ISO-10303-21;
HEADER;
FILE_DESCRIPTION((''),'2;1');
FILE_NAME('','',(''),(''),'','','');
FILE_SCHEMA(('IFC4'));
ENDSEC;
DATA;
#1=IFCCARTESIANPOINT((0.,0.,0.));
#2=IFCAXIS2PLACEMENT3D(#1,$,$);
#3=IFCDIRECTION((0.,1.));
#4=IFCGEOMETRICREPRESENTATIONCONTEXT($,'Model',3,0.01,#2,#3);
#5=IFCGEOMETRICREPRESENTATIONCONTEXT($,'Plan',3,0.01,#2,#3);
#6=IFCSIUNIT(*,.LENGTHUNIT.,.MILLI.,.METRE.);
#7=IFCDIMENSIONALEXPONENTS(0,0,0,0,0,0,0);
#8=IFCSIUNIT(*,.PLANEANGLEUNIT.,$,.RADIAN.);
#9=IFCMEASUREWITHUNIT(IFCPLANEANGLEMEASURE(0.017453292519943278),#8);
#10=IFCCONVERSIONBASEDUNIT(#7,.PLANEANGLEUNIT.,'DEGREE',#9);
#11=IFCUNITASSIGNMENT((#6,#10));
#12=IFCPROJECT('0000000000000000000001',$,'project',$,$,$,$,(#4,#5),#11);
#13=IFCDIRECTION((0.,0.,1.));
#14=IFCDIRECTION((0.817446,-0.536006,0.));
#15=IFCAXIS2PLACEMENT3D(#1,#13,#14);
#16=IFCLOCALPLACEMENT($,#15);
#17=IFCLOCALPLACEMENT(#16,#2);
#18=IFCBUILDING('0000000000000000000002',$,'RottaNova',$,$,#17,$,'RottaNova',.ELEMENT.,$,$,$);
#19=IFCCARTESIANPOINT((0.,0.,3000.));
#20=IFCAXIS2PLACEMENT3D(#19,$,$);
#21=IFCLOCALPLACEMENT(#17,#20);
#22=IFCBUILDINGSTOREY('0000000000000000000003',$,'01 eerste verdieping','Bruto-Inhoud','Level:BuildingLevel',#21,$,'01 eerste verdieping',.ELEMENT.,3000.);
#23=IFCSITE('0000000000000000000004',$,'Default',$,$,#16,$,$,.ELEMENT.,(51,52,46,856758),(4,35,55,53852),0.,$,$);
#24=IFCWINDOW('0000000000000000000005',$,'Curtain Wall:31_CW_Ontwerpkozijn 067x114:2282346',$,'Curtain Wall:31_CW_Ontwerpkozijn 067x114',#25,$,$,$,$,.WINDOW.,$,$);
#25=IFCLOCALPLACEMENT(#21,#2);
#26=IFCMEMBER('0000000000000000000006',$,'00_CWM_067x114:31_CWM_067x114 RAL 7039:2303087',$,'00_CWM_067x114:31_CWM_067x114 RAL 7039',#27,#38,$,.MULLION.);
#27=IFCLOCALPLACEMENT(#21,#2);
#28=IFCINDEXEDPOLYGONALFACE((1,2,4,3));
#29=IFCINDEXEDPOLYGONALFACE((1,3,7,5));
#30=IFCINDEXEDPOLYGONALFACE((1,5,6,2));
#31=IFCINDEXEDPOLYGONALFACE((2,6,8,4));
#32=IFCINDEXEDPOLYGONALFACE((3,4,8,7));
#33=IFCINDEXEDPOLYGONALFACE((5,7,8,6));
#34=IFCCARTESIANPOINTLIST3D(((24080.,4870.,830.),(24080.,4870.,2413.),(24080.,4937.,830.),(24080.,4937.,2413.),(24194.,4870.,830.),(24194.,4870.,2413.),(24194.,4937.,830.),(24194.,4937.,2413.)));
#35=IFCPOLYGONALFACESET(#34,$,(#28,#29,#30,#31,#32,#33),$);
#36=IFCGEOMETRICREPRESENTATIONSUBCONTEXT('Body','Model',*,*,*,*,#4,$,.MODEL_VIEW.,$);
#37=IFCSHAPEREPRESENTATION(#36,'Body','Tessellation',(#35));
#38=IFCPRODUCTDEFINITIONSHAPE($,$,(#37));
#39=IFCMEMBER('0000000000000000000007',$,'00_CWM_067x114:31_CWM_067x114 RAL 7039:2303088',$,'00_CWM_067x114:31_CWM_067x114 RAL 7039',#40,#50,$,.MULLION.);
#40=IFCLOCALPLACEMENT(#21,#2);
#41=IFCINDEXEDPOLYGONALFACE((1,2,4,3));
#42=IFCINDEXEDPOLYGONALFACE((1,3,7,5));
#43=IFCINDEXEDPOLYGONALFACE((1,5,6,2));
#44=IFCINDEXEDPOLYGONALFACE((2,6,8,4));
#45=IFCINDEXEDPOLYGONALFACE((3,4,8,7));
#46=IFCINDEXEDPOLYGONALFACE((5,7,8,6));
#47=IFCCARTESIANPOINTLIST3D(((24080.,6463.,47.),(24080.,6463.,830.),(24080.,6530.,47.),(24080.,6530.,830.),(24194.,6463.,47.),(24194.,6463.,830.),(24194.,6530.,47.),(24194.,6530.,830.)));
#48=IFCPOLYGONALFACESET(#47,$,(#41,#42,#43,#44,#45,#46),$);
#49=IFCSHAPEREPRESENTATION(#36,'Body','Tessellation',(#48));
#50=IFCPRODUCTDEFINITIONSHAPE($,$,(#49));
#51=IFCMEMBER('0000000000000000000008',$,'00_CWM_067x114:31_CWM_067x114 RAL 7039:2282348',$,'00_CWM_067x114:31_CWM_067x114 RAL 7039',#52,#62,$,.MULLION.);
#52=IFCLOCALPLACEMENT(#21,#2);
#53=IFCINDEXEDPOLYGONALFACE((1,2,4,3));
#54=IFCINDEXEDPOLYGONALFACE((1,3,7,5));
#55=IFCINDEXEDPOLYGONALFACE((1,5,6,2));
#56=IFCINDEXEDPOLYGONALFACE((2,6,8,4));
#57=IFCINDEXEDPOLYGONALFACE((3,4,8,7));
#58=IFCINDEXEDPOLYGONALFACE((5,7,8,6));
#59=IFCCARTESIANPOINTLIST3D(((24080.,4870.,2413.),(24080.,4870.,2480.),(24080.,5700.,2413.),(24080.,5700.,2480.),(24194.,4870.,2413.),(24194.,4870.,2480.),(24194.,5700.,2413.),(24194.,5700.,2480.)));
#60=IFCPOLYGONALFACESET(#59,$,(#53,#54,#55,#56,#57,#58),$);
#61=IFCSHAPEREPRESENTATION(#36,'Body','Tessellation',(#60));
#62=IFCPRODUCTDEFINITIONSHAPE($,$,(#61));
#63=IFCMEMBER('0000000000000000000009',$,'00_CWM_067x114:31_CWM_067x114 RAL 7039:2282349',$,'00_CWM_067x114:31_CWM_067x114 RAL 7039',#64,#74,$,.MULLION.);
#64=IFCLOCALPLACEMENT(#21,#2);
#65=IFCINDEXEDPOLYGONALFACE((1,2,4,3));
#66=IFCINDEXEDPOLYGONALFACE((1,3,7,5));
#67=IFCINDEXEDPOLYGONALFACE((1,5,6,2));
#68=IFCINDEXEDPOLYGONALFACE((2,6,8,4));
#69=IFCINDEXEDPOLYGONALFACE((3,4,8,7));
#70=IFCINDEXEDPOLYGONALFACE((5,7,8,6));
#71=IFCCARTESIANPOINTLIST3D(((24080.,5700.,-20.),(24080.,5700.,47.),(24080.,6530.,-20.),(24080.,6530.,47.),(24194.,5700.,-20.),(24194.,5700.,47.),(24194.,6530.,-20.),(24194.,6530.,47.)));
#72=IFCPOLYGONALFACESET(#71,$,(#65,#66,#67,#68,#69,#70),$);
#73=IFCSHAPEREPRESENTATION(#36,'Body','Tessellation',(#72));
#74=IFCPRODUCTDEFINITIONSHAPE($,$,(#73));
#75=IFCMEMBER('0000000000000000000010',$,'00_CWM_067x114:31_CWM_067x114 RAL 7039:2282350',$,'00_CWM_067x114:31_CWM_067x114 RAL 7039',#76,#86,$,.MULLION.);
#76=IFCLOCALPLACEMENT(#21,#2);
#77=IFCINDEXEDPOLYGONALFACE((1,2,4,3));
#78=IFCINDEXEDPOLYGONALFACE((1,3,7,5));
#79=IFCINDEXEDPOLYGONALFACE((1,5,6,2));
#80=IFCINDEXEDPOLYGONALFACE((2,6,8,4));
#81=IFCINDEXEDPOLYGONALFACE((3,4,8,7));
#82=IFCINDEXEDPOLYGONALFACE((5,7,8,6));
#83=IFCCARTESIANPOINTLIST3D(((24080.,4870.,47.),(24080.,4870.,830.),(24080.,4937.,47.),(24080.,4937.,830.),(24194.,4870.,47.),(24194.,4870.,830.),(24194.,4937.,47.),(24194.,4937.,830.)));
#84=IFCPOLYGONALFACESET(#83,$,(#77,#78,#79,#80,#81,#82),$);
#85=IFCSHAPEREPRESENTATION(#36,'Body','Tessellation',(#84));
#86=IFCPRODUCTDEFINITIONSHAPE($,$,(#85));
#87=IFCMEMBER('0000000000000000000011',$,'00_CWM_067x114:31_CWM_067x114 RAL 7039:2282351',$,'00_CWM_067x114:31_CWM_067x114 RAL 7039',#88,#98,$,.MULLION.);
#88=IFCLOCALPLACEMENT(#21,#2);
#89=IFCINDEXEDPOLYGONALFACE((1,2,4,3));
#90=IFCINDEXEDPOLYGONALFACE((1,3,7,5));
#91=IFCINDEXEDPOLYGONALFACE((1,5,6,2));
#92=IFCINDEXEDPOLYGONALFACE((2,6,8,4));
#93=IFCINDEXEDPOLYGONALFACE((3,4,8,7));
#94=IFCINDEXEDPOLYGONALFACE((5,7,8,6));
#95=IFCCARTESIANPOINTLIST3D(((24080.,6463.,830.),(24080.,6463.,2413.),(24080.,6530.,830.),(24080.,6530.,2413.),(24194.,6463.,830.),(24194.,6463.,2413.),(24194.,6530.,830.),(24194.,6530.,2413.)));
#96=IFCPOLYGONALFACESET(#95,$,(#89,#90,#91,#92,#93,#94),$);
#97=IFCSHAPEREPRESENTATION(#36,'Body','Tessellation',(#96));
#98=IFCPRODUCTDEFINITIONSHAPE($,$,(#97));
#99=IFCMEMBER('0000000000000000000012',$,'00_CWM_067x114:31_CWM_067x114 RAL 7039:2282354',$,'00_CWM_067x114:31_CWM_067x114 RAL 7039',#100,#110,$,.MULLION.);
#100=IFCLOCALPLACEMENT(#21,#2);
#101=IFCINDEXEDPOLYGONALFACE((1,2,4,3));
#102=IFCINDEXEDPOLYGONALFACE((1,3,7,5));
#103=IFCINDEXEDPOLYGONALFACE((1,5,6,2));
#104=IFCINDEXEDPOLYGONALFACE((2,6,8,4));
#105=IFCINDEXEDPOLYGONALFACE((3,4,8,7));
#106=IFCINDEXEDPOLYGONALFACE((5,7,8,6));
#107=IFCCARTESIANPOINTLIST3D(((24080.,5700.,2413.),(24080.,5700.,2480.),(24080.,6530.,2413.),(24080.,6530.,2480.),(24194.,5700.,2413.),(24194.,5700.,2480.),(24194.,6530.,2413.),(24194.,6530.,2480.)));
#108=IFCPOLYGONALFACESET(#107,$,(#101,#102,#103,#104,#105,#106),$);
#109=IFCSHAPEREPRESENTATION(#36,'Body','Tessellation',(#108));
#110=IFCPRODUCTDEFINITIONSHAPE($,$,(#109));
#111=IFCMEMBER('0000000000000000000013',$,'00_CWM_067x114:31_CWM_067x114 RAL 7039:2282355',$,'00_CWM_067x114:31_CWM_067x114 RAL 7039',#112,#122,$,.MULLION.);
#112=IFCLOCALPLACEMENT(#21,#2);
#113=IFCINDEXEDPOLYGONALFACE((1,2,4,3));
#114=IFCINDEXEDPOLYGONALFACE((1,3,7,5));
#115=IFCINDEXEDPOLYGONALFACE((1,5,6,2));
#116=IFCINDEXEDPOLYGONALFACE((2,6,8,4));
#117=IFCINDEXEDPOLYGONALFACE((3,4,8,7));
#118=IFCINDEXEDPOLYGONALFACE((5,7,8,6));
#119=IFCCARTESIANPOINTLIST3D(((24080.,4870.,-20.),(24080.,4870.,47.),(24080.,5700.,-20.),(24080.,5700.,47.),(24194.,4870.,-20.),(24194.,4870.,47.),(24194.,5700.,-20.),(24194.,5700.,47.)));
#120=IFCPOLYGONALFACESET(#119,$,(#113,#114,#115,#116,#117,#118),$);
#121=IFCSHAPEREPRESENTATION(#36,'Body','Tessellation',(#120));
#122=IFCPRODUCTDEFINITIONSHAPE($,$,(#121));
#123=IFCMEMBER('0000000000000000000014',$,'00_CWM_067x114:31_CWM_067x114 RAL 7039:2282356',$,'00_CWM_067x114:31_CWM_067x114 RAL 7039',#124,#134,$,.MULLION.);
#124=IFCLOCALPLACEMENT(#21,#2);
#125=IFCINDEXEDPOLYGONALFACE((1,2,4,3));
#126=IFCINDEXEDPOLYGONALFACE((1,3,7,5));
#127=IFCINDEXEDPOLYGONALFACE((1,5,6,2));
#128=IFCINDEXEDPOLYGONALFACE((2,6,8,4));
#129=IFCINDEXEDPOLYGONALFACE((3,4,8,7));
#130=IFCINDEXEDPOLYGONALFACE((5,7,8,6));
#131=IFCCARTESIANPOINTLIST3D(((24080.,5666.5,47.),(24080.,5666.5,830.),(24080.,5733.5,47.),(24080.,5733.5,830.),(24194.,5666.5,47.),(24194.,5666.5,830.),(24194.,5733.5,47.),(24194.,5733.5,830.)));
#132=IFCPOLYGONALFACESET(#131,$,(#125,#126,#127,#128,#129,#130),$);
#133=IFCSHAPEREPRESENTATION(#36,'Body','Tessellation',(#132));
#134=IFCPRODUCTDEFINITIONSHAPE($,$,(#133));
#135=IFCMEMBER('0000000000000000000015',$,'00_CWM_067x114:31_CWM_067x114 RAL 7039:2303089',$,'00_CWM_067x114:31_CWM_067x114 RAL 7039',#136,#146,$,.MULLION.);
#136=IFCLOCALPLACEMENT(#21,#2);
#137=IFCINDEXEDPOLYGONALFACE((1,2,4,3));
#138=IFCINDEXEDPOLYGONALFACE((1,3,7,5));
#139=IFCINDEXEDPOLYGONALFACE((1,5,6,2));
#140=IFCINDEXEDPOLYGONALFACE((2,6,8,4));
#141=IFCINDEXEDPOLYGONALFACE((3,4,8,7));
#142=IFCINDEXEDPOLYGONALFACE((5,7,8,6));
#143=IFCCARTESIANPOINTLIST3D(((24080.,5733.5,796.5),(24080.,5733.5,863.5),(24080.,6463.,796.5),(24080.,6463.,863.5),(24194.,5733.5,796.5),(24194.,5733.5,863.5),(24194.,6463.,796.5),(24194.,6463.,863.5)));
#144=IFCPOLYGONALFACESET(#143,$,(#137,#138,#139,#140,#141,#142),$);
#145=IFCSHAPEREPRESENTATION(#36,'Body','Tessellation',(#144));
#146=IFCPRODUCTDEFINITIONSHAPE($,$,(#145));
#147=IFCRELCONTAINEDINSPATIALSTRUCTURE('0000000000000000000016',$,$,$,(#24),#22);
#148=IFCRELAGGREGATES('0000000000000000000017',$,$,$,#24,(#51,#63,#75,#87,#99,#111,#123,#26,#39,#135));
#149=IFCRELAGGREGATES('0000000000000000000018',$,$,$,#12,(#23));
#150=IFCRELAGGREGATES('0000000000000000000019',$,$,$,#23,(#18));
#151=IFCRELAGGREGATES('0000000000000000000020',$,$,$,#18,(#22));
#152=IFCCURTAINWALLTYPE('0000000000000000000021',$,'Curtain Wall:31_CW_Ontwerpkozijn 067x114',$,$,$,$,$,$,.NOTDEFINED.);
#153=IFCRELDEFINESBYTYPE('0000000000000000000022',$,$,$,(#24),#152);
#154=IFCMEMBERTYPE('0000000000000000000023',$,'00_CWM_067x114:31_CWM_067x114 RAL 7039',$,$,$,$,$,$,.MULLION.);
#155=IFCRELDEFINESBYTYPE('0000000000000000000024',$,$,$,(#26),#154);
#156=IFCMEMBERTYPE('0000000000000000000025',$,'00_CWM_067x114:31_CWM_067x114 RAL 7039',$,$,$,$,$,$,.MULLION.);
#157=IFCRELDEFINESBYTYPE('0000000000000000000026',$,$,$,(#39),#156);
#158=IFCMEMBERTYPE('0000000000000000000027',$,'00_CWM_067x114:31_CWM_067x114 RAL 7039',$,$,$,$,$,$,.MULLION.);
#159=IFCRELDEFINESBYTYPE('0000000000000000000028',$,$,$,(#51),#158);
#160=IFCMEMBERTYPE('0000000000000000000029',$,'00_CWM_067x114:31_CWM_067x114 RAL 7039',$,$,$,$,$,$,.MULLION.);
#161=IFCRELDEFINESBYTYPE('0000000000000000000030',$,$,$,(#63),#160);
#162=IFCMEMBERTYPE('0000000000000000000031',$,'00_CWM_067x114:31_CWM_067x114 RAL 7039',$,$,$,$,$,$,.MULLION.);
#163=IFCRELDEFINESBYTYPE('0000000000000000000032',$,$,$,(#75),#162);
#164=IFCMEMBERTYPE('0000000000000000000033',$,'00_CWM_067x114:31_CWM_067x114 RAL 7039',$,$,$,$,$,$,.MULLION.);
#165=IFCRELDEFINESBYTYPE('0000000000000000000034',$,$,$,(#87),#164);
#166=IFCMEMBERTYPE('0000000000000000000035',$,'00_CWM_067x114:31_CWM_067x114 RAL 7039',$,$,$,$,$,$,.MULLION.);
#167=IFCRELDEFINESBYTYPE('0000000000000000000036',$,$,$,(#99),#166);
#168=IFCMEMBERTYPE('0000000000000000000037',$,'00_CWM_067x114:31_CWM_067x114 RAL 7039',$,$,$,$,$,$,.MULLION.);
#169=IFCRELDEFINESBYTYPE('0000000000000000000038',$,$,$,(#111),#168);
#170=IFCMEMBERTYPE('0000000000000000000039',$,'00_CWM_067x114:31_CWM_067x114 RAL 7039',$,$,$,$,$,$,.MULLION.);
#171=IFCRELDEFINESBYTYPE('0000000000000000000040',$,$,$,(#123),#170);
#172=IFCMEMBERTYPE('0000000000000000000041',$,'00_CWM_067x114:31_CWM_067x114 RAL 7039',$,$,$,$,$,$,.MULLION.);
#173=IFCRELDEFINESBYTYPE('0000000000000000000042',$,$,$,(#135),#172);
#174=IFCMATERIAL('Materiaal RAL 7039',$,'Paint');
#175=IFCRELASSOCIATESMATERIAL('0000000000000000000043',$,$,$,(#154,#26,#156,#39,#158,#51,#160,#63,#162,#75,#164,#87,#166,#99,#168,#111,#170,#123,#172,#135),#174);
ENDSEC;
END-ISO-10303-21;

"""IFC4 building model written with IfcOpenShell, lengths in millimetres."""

from ifc_helpers import new_model, entity, si_unit, converted_unit, direction, frame, origin, place, context, subcontext, project, spatial, indexed_curve, outline, extrude, source, transform, mapped, material, type_object, type_shapes, element, aggregate, save


model = new_model("IFC4")

# Units and contexts
model_context = context("Model", 3, precision=0.01, world=origin(), true_north=direction((0.0, 1.0)))
plan_context = context("Plan", 3, precision=0.01, world=origin(), true_north=direction((0.0, 1.0)))
body_context = subcontext(model_context, "Body", "Model", "MODEL_VIEW")
ifc_project = project(units=[si_unit("LENGTHUNIT", "METRE", prefix="MILLI"), converted_unit("PLANEANGLEUNIT", "DEGREE", entity("IfcPlaneAngleMeasure", 0.017453292519943278), si_unit("PLANEANGLEUNIT", "RADIAN"), dimensions=[0, 0, 0, 0, 0, 0, 0])], contexts=[model_context, plan_context])

# Site, building, storey
site_placement = place(None, frame((0.0, 0.0, 0.0), z_axis=(0.0, 0.0, 1.0), x_axis=(0.817446, -0.536006, 0.0)))
site = spatial("IfcSite", under=ifc_project, at=site_placement, Name="Default", CompositionType="ELEMENT", RefLatitude=(51, 52, 46, 856758), RefLongitude=(4, 35, 55, 53852), RefElevation=0.0)
building_placement = place(site_placement, origin())
building = spatial("IfcBuilding", under=site, at=building_placement, Name="RottaNova", LongName="RottaNova", CompositionType="ELEMENT")
storey_placement = place(building_placement, frame((0.0, 0.0, 3000.0)))
storey = spatial("IfcBuildingStorey", under=building, at=storey_placement, Name="01 eerste verdieping", Description="Bruto-Inhoud", ObjectType="Level:BuildingLevel", LongName="01 eerste verdieping", CompositionType="ELEMENT", Elevation=3000.0)

# Window, members
curtain_wall_type = type_object("IfcCurtainWallType", Name="Curtain Wall:31_CW_Ontwerpkozijn 067x114", PredefinedType="NOTDEFINED")
window_placement = place(storey_placement, frame((0.0, 0.0, -3000.0)))
window = element("IfcWindow", 1, at=window_placement, inside=storey, type_object=curtain_wall_type, Name="Curtain Wall:31_CW_Ontwerpkozijn 067x114:2282346", ObjectType="Curtain Wall:31_CW_Ontwerpkozijn 067x114", PredefinedType="WINDOW")
ifc_material_1 = material(Name="Materiaal RAL 7039", Category="Paint")
member_type_1 = type_object("IfcMemberType", Name="00_CWM_067x114:31_CWM_067x114 RAL 7039", PredefinedType="MULLION", material=ifc_material_1)
shared_shape_1 = source(origin(), body_context, "Body", "SweptSolid", [
    extrude(outline(indexed_curve([(-33.5, -57.0), (33.5, -57.0), (33.5, 57.0), (-33.5, 57.0), (-33.5, -57.0)], self_intersect=False)), frame((-33.5, -57.0, -1583.0), z_axis=(0.0, 0.0, 1.0), x_axis=(-1.0, 0.0, 0.0)), (0.0, 0.0, 1.0), 1583.0),
])
type_shapes(member_type_1, [shared_shape_1])
member_1_placement = place(window_placement, frame((24080.0, 4870.0, 3830.0), z_axis=(0.0, 0.0, -1.0), x_axis=(0.0, -1.0, 0.0)))
member_1 = element("IfcMember", 2, at=member_1_placement, type_object=member_type_1, material=ifc_material_1, Name="00_CWM_067x114:31_CWM_067x114 RAL 7039:2303087", ObjectType="00_CWM_067x114:31_CWM_067x114 RAL 7039", PredefinedType="MULLION", context=body_context, shape_type="MappedRepresentation", body=[
    mapped(shared_shape_1, transform((0.0, 0.0, 0.0), scale=1.0)),
])
member_type_2 = type_object("IfcMemberType", Name="00_CWM_067x114:31_CWM_067x114 RAL 7039", PredefinedType="MULLION", material=ifc_material_1)
shared_shape_2 = source(origin(), body_context, "Body", "SweptSolid", [
    extrude(outline(indexed_curve([(-33.5, -57.0), (33.5, -57.0), (33.5, 57.0), (-33.5, 57.0), (-33.5, -57.0)], self_intersect=False)), frame((-33.5, -57.0, -783.0), z_axis=(0.0, 0.0, 1.0), x_axis=(-1.0, 0.0, 0.0)), (0.0, 0.0, 1.0), 783.0),
])
type_shapes(member_type_2, [shared_shape_2])
member_2_placement = place(window_placement, frame((24080.0, 6530.0, 3830.0), z_axis=(0.0, 0.0, 1.0), x_axis=(0.0, 1.0, 0.0)))
member_2 = element("IfcMember", 3, at=member_2_placement, type_object=member_type_2, material=ifc_material_1, Name="00_CWM_067x114:31_CWM_067x114 RAL 7039:2303088", ObjectType="00_CWM_067x114:31_CWM_067x114 RAL 7039", PredefinedType="MULLION", context=body_context, shape_type="MappedRepresentation", body=[
    mapped(shared_shape_2, transform((0.0, 0.0, 0.0), scale=1.0)),
])
member_type_3 = type_object("IfcMemberType", Name="00_CWM_067x114:31_CWM_067x114 RAL 7039", PredefinedType="MULLION", material=ifc_material_1)
shared_shape_3 = source(origin(), body_context, "Body", "SweptSolid", [
    extrude(outline(indexed_curve([(-33.5, -57.0), (33.5, -57.0), (33.5, 57.0), (-33.5, 57.0), (-33.5, -57.0)], self_intersect=False)), frame((-33.5, -57.0, -830.0), z_axis=(0.0, 0.0, 1.0), x_axis=(-1.0, 0.0, 0.0)), (0.0, 0.0, 1.0), 830.0),
])
type_shapes(member_type_3, [shared_shape_3])
member_3_placement = place(window_placement, frame((24080.0, 4870.0, 5480.0), z_axis=(0.0, -1.0, 0.0), x_axis=(0.0, 0.0, 1.0)))
member_3 = element("IfcMember", 4, at=member_3_placement, type_object=member_type_3, material=ifc_material_1, Name="00_CWM_067x114:31_CWM_067x114 RAL 7039:2282348", ObjectType="00_CWM_067x114:31_CWM_067x114 RAL 7039", PredefinedType="MULLION", context=body_context, shape_type="MappedRepresentation", body=[
    mapped(shared_shape_3, transform((0.0, 0.0, 0.0), scale=1.0)),
])
member_type_4 = type_object("IfcMemberType", Name="00_CWM_067x114:31_CWM_067x114 RAL 7039", PredefinedType="MULLION", material=ifc_material_1)
shared_shape_4 = source(origin(), body_context, "Body", "SweptSolid", [
    extrude(outline(indexed_curve([(-33.5, -57.0), (33.5, -57.0), (33.5, 57.0), (-33.5, 57.0), (-33.5, -57.0)], self_intersect=False)), frame((-33.5, -57.0, -830.0), z_axis=(0.0, 0.0, 1.0), x_axis=(-1.0, 0.0, 0.0)), (0.0, 0.0, 1.0), 830.0),
])
type_shapes(member_type_4, [shared_shape_4])
member_4_placement = place(window_placement, frame((24080.0, 6530.0, 2980.0), z_axis=(0.0, 1.0, 0.0), x_axis=(0.0, 0.0, -1.0)))
member_4 = element("IfcMember", 5, at=member_4_placement, type_object=member_type_4, material=ifc_material_1, Name="00_CWM_067x114:31_CWM_067x114 RAL 7039:2282349", ObjectType="00_CWM_067x114:31_CWM_067x114 RAL 7039", PredefinedType="MULLION", context=body_context, shape_type="MappedRepresentation", body=[
    mapped(shared_shape_4, transform((0.0, 0.0, 0.0), scale=1.0)),
])
member_type_5 = type_object("IfcMemberType", Name="00_CWM_067x114:31_CWM_067x114 RAL 7039", PredefinedType="MULLION", material=ifc_material_1)
shared_shape_5 = source(origin(), body_context, "Body", "SweptSolid", [
    extrude(outline(indexed_curve([(-33.5, -57.0), (33.5, -57.0), (33.5, 57.0), (-33.5, 57.0), (-33.5, -57.0)], self_intersect=False)), frame((-33.5, -57.0, -783.0), z_axis=(0.0, 0.0, 1.0), x_axis=(-1.0, 0.0, 0.0)), (0.0, 0.0, 1.0), 783.0),
])
type_shapes(member_type_5, [shared_shape_5])
member_5_placement = place(window_placement, frame((24080.0, 4870.0, 3047.0), z_axis=(0.0, 0.0, -1.0), x_axis=(0.0, -1.0, 0.0)))
member_5 = element("IfcMember", 6, at=member_5_placement, type_object=member_type_5, material=ifc_material_1, Name="00_CWM_067x114:31_CWM_067x114 RAL 7039:2282350", ObjectType="00_CWM_067x114:31_CWM_067x114 RAL 7039", PredefinedType="MULLION", context=body_context, shape_type="MappedRepresentation", body=[
    mapped(shared_shape_5, transform((0.0, 0.0, 0.0), scale=1.0)),
])
member_type_6 = type_object("IfcMemberType", Name="00_CWM_067x114:31_CWM_067x114 RAL 7039", PredefinedType="MULLION", material=ifc_material_1)
shared_shape_6 = source(origin(), body_context, "Body", "SweptSolid", [
    extrude(outline(indexed_curve([(-33.5, -57.0), (33.5, -57.0), (33.5, 57.0), (-33.5, 57.0), (-33.5, -57.0)], self_intersect=False)), frame((-33.5, -57.0, -1583.0), z_axis=(0.0, 0.0, 1.0), x_axis=(-1.0, 0.0, 0.0)), (0.0, 0.0, 1.0), 1583.0),
])
type_shapes(member_type_6, [shared_shape_6])
member_6_placement = place(window_placement, frame((24080.0, 6530.0, 5413.0), z_axis=(0.0, 0.0, 1.0), x_axis=(0.0, 1.0, 0.0)))
member_6 = element("IfcMember", 7, at=member_6_placement, type_object=member_type_6, material=ifc_material_1, Name="00_CWM_067x114:31_CWM_067x114 RAL 7039:2282351", ObjectType="00_CWM_067x114:31_CWM_067x114 RAL 7039", PredefinedType="MULLION", context=body_context, shape_type="MappedRepresentation", body=[
    mapped(shared_shape_6, transform((0.0, 0.0, 0.0), scale=1.0)),
])
member_type_7 = type_object("IfcMemberType", Name="00_CWM_067x114:31_CWM_067x114 RAL 7039", PredefinedType="MULLION", material=ifc_material_1)
shared_shape_7 = source(origin(), body_context, "Body", "SweptSolid", [
    extrude(outline(indexed_curve([(-33.5, -57.0), (33.5, -57.0), (33.5, 57.0), (-33.5, 57.0), (-33.5, -57.0)], self_intersect=False)), frame((-33.5, -57.0, -830.0), z_axis=(0.0, 0.0, 1.0), x_axis=(-1.0, 0.0, 0.0)), (0.0, 0.0, 1.0), 830.0),
])
type_shapes(member_type_7, [shared_shape_7])
member_7_placement = place(window_placement, frame((24080.0, 5700.0, 5480.0), z_axis=(0.0, -1.0, 0.0), x_axis=(0.0, 0.0, 1.0)))
member_7 = element("IfcMember", 8, at=member_7_placement, type_object=member_type_7, material=ifc_material_1, Name="00_CWM_067x114:31_CWM_067x114 RAL 7039:2282354", ObjectType="00_CWM_067x114:31_CWM_067x114 RAL 7039", PredefinedType="MULLION", context=body_context, shape_type="MappedRepresentation", body=[
    mapped(shared_shape_7, transform((0.0, 0.0, 0.0), scale=1.0)),
])
member_type_8 = type_object("IfcMemberType", Name="00_CWM_067x114:31_CWM_067x114 RAL 7039", PredefinedType="MULLION", material=ifc_material_1)
shared_shape_8 = source(origin(), body_context, "Body", "SweptSolid", [
    extrude(outline(indexed_curve([(-33.5, -57.0), (33.5, -57.0), (33.5, 57.0), (-33.5, 57.0), (-33.5, -57.0)], self_intersect=False)), frame((-33.5, -57.0, -830.0), z_axis=(0.0, 0.0, 1.0), x_axis=(-1.0, 0.0, 0.0)), (0.0, 0.0, 1.0), 830.0),
])
type_shapes(member_type_8, [shared_shape_8])
member_8_placement = place(window_placement, frame((24080.0, 5700.0, 2980.0), z_axis=(0.0, 1.0, 0.0), x_axis=(0.0, 0.0, -1.0)))
member_8 = element("IfcMember", 9, at=member_8_placement, type_object=member_type_8, material=ifc_material_1, Name="00_CWM_067x114:31_CWM_067x114 RAL 7039:2282355", ObjectType="00_CWM_067x114:31_CWM_067x114 RAL 7039", PredefinedType="MULLION", context=body_context, shape_type="MappedRepresentation", body=[
    mapped(shared_shape_8, transform((0.0, 0.0, 0.0), scale=1.0)),
])
member_type_9 = type_object("IfcMemberType", Name="00_CWM_067x114:31_CWM_067x114 RAL 7039", PredefinedType="MULLION", material=ifc_material_1)
shared_shape_9 = source(origin(), body_context, "Body", "SweptSolid", [
    extrude(outline(indexed_curve([(-33.5, -57.0), (33.5, -57.0), (33.5, 57.0), (-33.5, 57.0), (-33.5, -57.0)], self_intersect=False)), frame((0.0, -57.0, -783.0), z_axis=(0.0, 0.0, 1.0), x_axis=(-1.0, 0.0, 0.0)), (0.0, 0.0, 1.0), 783.0),
])
type_shapes(member_type_9, [shared_shape_9])
member_9_placement = place(window_placement, frame((24080.0, 5700.0, 3047.0), z_axis=(0.0, 0.0, -1.0), x_axis=(0.0, -1.0, 0.0)))
member_9 = element("IfcMember", 10, at=member_9_placement, type_object=member_type_9, material=ifc_material_1, Name="00_CWM_067x114:31_CWM_067x114 RAL 7039:2282356", ObjectType="00_CWM_067x114:31_CWM_067x114 RAL 7039", PredefinedType="MULLION", context=body_context, shape_type="MappedRepresentation", body=[
    mapped(shared_shape_9, transform((0.0, 0.0, 0.0), scale=1.0)),
])
member_type_10 = type_object("IfcMemberType", Name="00_CWM_067x114:31_CWM_067x114 RAL 7039", PredefinedType="MULLION", material=ifc_material_1)
shared_shape_10 = source(origin(), body_context, "Body", "SweptSolid", [
    extrude(outline(indexed_curve([(-33.5, -57.0), (33.5, -57.0), (33.5, 57.0), (-33.5, 57.0), (-33.5, -57.0)], self_intersect=False)), frame((0.0, -57.0, -729.5), z_axis=(0.0, 0.0, 1.0), x_axis=(-1.0, 0.0, 0.0)), (0.0, 0.0, 1.0), 729.5),
])
type_shapes(member_type_10, [shared_shape_10])
member_10_placement = place(window_placement, frame((24080.0, 5733.5, 3830.0), z_axis=(0.0, -1.0, 0.0), x_axis=(0.0, 0.0, 1.0)))
member_10 = element("IfcMember", 11, at=member_10_placement, type_object=member_type_10, material=ifc_material_1, Name="00_CWM_067x114:31_CWM_067x114 RAL 7039:2303089", ObjectType="00_CWM_067x114:31_CWM_067x114 RAL 7039", PredefinedType="MULLION", context=body_context, shape_type="MappedRepresentation", body=[
    mapped(shared_shape_10, transform((0.0, 0.0, 0.0), scale=1.0)),
])
aggregate(window, [member_3, member_4, member_5, member_6, member_7, member_8, member_9, member_1, member_2, member_10])

save(model, "model.ifc")
